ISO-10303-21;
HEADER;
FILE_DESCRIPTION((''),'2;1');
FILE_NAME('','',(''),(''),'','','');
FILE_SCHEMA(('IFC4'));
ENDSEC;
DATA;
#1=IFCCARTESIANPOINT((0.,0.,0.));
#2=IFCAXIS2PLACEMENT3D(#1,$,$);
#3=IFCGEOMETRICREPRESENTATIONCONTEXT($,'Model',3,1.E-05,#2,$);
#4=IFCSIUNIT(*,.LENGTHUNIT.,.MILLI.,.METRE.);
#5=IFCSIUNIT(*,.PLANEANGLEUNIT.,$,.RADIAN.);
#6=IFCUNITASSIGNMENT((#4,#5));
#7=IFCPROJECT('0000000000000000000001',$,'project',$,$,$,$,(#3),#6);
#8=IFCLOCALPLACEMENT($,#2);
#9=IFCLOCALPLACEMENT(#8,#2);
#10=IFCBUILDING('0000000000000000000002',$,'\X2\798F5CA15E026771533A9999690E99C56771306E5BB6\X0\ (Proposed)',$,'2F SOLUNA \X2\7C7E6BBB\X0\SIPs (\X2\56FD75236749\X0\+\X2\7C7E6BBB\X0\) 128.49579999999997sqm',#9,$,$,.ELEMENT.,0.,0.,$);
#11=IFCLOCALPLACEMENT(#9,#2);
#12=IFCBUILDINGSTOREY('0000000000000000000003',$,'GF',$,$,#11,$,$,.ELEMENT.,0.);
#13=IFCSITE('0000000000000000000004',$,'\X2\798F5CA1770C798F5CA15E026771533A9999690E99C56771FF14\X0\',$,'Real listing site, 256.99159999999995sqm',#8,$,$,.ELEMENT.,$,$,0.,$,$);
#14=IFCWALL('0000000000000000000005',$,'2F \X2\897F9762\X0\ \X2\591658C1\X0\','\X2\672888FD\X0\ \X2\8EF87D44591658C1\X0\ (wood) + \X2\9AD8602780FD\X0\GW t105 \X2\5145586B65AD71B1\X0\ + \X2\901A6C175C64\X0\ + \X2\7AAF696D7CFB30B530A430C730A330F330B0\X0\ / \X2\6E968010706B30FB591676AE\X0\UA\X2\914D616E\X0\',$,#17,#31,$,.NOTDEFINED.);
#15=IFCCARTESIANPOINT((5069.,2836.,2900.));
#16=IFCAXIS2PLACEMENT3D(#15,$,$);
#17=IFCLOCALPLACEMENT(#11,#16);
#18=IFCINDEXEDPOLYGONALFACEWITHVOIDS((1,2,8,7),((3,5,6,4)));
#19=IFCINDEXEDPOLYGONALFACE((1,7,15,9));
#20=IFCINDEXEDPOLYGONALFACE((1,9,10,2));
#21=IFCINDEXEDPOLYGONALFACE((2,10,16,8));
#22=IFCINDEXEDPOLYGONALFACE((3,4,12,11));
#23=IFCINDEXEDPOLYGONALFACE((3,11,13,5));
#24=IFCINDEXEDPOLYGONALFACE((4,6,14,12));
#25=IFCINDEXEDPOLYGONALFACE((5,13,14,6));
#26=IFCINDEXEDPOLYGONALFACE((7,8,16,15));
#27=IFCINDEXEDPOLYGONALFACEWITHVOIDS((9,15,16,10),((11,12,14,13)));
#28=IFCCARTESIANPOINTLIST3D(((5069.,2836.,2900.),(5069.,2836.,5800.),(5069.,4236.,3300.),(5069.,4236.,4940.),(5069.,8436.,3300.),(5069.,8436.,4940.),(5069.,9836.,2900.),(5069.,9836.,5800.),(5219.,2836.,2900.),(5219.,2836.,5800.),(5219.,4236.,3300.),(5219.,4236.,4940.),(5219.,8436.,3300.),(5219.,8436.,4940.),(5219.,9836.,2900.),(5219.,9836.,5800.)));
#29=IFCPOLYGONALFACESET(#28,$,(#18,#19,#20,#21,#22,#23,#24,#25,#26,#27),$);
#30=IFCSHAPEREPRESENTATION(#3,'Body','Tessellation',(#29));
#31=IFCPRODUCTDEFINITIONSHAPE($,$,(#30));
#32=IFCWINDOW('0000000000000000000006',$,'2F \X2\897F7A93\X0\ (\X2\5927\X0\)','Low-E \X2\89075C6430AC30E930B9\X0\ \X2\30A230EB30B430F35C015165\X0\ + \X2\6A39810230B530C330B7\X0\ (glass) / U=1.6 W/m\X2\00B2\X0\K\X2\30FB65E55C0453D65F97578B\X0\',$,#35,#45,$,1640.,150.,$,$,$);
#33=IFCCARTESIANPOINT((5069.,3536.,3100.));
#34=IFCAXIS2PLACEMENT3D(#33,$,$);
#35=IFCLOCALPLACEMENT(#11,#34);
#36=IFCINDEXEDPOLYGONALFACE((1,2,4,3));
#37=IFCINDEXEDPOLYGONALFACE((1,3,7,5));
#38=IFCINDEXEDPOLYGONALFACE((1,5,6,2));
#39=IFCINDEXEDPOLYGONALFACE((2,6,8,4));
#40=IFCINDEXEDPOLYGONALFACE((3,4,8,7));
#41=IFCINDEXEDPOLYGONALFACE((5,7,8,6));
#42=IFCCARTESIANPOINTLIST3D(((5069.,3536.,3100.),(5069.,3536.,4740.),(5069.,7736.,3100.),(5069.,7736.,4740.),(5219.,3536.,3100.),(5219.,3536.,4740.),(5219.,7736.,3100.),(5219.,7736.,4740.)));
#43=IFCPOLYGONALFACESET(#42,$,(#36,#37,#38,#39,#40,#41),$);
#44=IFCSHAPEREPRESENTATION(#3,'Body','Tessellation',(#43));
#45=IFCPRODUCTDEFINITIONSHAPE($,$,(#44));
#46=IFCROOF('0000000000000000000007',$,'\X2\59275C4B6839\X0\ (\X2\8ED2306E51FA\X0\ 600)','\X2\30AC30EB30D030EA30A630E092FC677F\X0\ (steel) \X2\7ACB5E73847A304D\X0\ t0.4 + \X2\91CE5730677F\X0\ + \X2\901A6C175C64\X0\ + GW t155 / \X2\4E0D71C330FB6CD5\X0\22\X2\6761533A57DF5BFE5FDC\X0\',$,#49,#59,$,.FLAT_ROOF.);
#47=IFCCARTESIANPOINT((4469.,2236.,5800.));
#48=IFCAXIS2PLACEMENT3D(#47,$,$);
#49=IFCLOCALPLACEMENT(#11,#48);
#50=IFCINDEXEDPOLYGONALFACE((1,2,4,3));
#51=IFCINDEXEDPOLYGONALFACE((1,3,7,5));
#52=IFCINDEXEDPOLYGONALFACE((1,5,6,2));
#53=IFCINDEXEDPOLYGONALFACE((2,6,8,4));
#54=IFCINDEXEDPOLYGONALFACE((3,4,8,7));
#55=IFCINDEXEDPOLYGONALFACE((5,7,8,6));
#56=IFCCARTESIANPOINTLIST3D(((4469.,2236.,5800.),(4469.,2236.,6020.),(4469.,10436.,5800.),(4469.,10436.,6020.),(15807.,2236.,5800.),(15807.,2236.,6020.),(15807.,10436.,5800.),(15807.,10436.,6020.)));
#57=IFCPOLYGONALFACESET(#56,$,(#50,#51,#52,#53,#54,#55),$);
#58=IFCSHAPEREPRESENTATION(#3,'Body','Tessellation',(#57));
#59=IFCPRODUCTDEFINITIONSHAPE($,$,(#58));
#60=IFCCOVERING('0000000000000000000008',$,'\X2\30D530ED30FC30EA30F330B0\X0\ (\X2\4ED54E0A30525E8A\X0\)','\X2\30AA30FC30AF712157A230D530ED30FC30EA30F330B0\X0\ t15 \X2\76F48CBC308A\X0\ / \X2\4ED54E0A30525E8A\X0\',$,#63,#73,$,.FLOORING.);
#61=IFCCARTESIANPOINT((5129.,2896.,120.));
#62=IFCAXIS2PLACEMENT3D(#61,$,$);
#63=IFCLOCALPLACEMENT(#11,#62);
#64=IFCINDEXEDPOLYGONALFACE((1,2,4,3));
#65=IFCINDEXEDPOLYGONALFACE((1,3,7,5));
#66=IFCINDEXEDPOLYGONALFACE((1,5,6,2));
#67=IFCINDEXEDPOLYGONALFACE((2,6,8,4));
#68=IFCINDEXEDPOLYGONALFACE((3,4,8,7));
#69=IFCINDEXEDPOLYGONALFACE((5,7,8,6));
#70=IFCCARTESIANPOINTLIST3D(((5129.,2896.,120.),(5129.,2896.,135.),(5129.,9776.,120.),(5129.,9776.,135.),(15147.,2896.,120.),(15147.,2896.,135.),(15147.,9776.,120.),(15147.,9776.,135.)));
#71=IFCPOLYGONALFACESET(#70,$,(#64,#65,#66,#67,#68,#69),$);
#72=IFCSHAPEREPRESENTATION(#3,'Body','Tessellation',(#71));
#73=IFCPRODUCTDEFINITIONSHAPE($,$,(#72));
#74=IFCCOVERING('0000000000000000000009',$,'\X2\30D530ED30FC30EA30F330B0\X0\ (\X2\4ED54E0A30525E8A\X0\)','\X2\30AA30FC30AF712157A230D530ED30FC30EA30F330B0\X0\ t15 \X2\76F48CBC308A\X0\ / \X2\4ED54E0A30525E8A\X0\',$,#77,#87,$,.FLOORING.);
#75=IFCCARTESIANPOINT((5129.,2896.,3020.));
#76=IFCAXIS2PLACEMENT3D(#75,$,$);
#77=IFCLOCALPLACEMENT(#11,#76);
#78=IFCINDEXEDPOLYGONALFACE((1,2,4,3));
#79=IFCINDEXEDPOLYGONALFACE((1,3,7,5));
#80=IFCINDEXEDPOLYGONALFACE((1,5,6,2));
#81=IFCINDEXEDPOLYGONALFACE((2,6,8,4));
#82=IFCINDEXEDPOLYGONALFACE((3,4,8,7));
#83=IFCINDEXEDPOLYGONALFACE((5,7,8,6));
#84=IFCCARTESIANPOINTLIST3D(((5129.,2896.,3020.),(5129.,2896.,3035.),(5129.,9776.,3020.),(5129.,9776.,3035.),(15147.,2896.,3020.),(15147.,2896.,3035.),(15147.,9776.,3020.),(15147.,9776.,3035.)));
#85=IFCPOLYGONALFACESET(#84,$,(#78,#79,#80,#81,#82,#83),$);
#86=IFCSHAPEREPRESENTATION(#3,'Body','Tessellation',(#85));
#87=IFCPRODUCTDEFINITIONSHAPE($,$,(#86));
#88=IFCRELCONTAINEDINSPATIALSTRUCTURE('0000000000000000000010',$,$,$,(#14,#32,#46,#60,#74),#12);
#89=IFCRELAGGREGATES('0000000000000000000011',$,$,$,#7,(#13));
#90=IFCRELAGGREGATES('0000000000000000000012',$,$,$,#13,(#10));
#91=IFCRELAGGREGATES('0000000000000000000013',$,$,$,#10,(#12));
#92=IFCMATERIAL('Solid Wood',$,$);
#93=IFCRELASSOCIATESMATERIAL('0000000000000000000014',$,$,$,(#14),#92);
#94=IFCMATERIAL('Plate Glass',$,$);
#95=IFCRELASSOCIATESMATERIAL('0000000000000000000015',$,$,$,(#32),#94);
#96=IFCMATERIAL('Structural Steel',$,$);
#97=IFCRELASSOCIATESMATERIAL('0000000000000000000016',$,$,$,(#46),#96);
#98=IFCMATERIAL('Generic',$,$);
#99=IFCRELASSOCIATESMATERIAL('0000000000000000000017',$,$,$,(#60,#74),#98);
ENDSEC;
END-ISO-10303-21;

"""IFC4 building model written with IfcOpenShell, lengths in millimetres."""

from ifc_helpers import new_model, si_unit, frame, frame_2d, origin, place, context, project, spatial, rectangle, extrude, material, element, fill, save


model = new_model("IFC4")

# Units and contexts
model_context = context("Model", 3, precision=1e-05, world=origin())
ifc_project = project(units=[si_unit("LENGTHUNIT", "METRE", prefix="MILLI"), si_unit("PLANEANGLEUNIT", "RADIAN")], contexts=[model_context])

# Site, building, storey
site_placement = place(None, origin())
site = spatial("IfcSite", under=ifc_project, at=site_placement, Name="福岡県福岡市東区香椎駅東４", ObjectType="Real listing site, 256.99159999999995sqm", CompositionType="ELEMENT", RefElevation=0.0)
building_placement = place(site_placement, origin())
building = spatial("IfcBuilding", under=site, at=building_placement, Name="福岡市東区香椎駅東の家 (Proposed)", ObjectType="2F SOLUNA 籾殻SIPs (国産杉+籾殻) 128.49579999999997sqm", CompositionType="ELEMENT", ElevationOfRefHeight=0.0, ElevationOfTerrain=0.0)
storey_placement = place(building_placement, origin())
storey = spatial("IfcBuildingStorey", under=building, at=storey_placement, Name="GF", CompositionType="ELEMENT", Elevation=0.0)

# Shared definitions
ifc_material_1 = material(Name="Solid Wood")

# Shared definitions
ifc_material_2 = material(Name="Plate Glass")

# Wall, opening, window
wall_1_placement = place(storey_placement, frame((5069.0, 2836.0, 2900.0)))
wall_1 = element("IfcWall", 1, at=wall_1_placement, inside=storey, material=ifc_material_1, Name="2F 西面 外壁", Description="木製 軸組外壁 (wood) + 高性能GW t105 充填断熱 + 通気層 + 窯業系サイディング / 準耐火・外皮UA配慮", PredefinedType="NOTDEFINED", context=model_context, shape_type="SweptSolid", body=[
    extrude(rectangle(XDim=150.0, YDim=7000.0, at=frame_2d((75.0, 3500.0))), frame((5069.0, 2836.0, 2900.0)), (0.0, 0.0, 1.0), 2900.0),
])
opening_1_placement = place(storey_placement, frame((5069.0, 3536.0, 3100.0)))
opening_1 = element("IfcOpeningElement", 2, at=opening_1_placement, cuts=wall_1, PredefinedType="NOTDEFINED", context=model_context, shape_type="SweptSolid", body=[
    extrude(rectangle(XDim=150.0, YDim=4200.0, at=frame_2d((75.0, 2100.0))), frame((5069.0, 3536.0, 3100.0)), (0.0, 0.0, 1.0), 1640.0),
])
window_1_placement = place(storey_placement, frame((5069.0, 3536.0, 3100.0)))
window_1 = element("IfcWindow", 3, at=window_1_placement, inside=storey, material=ifc_material_2, Name="2F 西窓 (大)", Description="Low-E 複層ガラス アルゴン封入 + 樹脂サッシ (glass) / U=1.6 W/m²K・日射取得型", OverallHeight=1640.0, OverallWidth=150.0, context=model_context, shape_type="SweptSolid", body=[
    extrude(rectangle(XDim=150.0, YDim=4200.0, at=frame_2d((75.0, 2100.0))), frame((5069.0, 3536.0, 3100.0)), (0.0, 0.0, 1.0), 1640.0),
])
fill(opening_1, window_1)

# Roof
ifc_material_3 = material(Name="Structural Steel")
roof_placement = place(storey_placement, frame((4469.0, 2236.0, 5800.0)))
element("IfcRoof", 4, at=roof_placement, inside=storey, material=ifc_material_3, Name="大屋根 (軒の出 600)", Description="ガルバリウム鋼板 (steel) 立平葺き t0.4 + 野地板 + 通気層 + GW t155 / 不燃・法22条区域対応", PredefinedType="FLAT_ROOF", context=model_context, shape_type="SweptSolid", body=[
    extrude(rectangle(XDim=11338.0, YDim=8200.0, at=frame_2d((5669.0, 4100.0))), frame((4469.0, 2236.0, 5800.0)), (0.0, 0.0, 1.0), 220.0),
])

# Coverings
ifc_material_4 = material(Name="Generic")
covering_1_placement = place(storey_placement, frame((5129.0, 2896.0, 120.0)))
element("IfcCovering", 5, at=covering_1_placement, inside=storey, material=ifc_material_4, Name="フローリング (仕上げ床)", Description="オーク無垢フローリング t15 直貼り / 仕上げ床", PredefinedType="FLOORING", context=model_context, shape_type="SweptSolid", body=[
    extrude(rectangle(XDim=10018.0, YDim=6880.0, at=frame_2d((5009.0, 3440.0))), frame((5129.0, 2896.0, 120.0)), (0.0, 0.0, 1.0), 15.0),
])
covering_2_placement = place(storey_placement, frame((5129.0, 2896.0, 3020.0)))
element("IfcCovering", 6, at=covering_2_placement, inside=storey, material=ifc_material_4, Name="フローリング (仕上げ床)", Description="オーク無垢フローリング t15 直貼り / 仕上げ床", PredefinedType="FLOORING", context=model_context, shape_type="SweptSolid", body=[
    extrude(rectangle(XDim=10018.0, YDim=6880.0, at=frame_2d((5009.0, 3440.0))), frame((5129.0, 2896.0, 3020.0)), (0.0, 0.0, 1.0), 15.0),
])

save(model, "model.ifc")
